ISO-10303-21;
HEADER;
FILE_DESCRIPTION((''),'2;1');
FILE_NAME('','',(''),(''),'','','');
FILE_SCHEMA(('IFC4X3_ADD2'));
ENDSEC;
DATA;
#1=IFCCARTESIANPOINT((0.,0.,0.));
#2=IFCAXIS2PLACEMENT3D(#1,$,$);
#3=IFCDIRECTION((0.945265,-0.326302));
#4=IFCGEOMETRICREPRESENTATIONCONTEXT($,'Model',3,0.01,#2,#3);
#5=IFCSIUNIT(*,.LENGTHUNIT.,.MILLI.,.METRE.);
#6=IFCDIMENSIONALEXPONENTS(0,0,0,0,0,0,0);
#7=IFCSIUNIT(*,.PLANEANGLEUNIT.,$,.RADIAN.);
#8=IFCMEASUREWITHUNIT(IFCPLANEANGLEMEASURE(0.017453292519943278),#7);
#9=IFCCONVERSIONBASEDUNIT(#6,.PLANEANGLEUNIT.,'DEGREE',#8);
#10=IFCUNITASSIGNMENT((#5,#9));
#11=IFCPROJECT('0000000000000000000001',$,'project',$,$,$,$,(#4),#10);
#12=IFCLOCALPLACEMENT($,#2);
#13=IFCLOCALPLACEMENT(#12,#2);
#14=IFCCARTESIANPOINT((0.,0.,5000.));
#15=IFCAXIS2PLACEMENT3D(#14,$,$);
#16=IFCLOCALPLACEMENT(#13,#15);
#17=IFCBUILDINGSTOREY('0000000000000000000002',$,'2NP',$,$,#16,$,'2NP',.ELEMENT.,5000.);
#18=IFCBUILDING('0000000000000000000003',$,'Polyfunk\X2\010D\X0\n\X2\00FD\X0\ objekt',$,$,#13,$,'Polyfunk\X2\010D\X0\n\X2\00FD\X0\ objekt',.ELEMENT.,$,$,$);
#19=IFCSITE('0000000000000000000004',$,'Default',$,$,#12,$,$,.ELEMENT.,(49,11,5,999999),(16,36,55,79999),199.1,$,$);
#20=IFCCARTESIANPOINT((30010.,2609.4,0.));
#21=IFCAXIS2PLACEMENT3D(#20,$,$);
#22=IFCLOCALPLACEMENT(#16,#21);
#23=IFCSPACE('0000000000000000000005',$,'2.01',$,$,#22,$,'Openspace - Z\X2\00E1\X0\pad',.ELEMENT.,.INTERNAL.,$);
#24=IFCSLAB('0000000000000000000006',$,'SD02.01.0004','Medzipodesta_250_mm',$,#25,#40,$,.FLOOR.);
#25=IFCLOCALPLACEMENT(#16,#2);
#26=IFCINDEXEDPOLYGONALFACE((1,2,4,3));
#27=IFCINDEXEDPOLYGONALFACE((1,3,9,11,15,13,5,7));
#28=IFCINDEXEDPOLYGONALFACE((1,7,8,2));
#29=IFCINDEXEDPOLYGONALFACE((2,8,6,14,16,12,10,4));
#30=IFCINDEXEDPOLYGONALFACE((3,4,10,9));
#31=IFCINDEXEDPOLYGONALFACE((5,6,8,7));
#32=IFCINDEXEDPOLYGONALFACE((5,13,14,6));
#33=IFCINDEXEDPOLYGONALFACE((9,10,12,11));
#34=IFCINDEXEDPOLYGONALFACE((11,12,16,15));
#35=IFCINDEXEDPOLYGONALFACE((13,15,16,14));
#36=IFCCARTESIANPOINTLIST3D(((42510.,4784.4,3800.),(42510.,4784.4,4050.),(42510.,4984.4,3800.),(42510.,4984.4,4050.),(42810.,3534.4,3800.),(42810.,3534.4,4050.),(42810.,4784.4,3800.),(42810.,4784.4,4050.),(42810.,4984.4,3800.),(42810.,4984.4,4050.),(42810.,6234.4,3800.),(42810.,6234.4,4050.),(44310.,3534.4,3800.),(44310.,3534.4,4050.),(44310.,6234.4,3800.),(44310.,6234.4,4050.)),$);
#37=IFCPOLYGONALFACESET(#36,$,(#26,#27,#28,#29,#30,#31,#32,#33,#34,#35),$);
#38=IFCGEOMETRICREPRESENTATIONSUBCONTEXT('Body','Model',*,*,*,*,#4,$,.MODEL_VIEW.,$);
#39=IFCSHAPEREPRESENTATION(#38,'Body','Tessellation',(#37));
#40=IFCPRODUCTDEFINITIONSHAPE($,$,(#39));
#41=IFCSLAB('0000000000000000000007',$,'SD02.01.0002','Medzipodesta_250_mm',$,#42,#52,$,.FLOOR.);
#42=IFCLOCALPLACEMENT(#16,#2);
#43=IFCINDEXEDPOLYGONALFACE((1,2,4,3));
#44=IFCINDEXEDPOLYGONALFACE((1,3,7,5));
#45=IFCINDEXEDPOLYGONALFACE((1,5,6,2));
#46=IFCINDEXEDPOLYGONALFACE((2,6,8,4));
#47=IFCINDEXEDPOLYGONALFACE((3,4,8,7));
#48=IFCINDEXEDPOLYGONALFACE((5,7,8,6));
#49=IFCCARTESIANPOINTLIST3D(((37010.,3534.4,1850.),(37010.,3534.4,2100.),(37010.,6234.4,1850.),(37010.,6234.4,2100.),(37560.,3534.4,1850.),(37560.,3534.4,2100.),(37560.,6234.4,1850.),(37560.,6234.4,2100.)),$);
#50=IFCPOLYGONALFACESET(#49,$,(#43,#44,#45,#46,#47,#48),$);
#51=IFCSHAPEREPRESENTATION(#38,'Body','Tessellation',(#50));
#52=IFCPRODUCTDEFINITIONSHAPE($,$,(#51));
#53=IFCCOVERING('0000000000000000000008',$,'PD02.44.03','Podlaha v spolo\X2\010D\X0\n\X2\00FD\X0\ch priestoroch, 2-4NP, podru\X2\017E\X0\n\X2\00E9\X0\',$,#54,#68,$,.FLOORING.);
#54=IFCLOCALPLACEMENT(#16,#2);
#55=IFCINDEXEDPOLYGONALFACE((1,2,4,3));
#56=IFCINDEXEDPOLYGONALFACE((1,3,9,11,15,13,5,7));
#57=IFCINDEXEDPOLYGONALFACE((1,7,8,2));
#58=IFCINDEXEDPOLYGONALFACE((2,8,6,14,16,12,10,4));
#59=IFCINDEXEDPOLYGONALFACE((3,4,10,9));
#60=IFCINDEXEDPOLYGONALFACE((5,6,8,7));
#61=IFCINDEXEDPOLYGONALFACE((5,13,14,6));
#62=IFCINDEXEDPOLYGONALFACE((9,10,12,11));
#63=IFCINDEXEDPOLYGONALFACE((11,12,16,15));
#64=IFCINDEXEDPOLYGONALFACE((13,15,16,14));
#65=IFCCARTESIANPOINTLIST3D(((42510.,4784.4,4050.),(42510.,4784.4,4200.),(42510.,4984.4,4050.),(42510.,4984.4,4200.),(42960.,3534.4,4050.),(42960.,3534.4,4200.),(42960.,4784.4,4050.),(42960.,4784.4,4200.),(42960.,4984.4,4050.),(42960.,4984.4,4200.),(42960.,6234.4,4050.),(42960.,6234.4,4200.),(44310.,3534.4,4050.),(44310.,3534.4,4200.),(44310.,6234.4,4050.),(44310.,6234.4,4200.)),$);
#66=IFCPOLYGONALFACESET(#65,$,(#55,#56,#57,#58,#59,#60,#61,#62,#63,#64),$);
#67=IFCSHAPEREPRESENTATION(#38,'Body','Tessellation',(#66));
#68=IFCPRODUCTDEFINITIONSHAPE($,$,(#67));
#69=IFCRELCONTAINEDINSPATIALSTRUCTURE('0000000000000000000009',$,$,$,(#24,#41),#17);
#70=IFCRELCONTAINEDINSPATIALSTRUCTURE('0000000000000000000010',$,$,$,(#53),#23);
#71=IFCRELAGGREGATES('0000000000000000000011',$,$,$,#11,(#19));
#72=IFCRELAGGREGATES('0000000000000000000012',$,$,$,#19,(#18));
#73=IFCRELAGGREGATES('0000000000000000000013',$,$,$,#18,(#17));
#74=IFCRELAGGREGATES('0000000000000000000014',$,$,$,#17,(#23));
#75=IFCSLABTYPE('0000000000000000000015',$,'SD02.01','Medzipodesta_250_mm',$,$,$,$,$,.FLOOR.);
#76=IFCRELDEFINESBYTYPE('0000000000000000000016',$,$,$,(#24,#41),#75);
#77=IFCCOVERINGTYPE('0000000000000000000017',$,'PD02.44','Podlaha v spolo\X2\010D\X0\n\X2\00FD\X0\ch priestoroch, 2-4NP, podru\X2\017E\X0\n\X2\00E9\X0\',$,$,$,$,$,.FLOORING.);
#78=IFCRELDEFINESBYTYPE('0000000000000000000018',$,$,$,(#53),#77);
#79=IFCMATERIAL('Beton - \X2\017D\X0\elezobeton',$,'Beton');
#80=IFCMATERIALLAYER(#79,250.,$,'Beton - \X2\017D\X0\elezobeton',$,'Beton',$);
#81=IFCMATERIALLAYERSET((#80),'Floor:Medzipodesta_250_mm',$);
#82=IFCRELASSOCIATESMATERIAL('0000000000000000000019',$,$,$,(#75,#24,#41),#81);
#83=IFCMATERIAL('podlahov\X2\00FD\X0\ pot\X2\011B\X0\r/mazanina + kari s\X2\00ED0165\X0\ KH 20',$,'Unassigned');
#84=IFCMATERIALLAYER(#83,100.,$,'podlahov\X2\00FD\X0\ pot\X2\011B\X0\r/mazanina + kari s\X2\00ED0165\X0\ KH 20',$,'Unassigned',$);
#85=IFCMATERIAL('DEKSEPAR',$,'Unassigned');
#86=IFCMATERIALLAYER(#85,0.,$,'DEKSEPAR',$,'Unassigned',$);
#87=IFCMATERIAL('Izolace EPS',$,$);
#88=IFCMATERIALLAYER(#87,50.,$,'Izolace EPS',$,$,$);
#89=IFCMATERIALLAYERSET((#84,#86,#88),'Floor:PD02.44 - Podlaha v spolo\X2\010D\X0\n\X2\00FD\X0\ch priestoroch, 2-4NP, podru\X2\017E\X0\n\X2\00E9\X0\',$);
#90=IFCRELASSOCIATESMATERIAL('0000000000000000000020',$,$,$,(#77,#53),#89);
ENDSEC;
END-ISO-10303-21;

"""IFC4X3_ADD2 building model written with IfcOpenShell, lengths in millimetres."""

from ifc_helpers import new_model, entity, si_unit, converted_unit, direction, frame, frame_2d, origin, place, context, subcontext, project, spatial, polyline, rectangle, outline, extrude, material, layer, layer_set, layer_usage, type_object, element, save


model = new_model("IFC4X3_ADD2")

# Units and contexts
model_context = context("Model", 3, precision=0.01, world=origin(), true_north=direction((0.945265, -0.326302)))
body_context = subcontext(model_context, "Body", "Model", "MODEL_VIEW")
ifc_project = project(units=[si_unit("LENGTHUNIT", "METRE", prefix="MILLI"), converted_unit("PLANEANGLEUNIT", "DEGREE", entity("IfcPlaneAngleMeasure", 0.017453292519943278), si_unit("PLANEANGLEUNIT", "RADIAN"), dimensions=[0, 0, 0, 0, 0, 0, 0])], contexts=[model_context])

# Site, building, storey
site_placement = place(None, origin())
site = spatial("IfcSite", under=ifc_project, at=site_placement, Name="Default", CompositionType="ELEMENT", RefLatitude=(49, 11, 5, 999999), RefLongitude=(16, 36, 55, 79999), RefElevation=199.1)
building_placement = place(site_placement, origin())
building = spatial("IfcBuilding", under=site, at=building_placement, Name="Polyfunkčný objekt", LongName="Polyfunkčný objekt", CompositionType="ELEMENT")
storey_placement = place(building_placement, frame((0.0, 0.0, 5000.0)))
storey = spatial("IfcBuildingStorey", under=building, at=storey_placement, Name="2NP", LongName="2NP", CompositionType="ELEMENT", Elevation=5000.0)

# Shared definitions
ifc_material_1 = material(Name="Beton - Železobeton", Category="Beton")

# Slabs
ifc_layer_1 = layer(ifc_material_1, 250.0, Name="Beton - Železobeton", Category="Beton")
ifc_layer_set_1 = layer_set([ifc_layer_1], Name="Floor:Medzipodesta_250_mm")
ifc_layer_usage_1 = layer_usage(ifc_layer_set_1, "AXIS3", "POSITIVE", 0.0)
slab_type_1 = type_object("IfcSlabType", Name="SD02.01", Description="Medzipodesta_250_mm", PredefinedType="FLOOR", material=ifc_layer_set_1)
slab_1_placement = place(storey_placement, origin())
element("IfcSlab", 1, at=slab_1_placement, inside=storey, type_object=slab_type_1, material=ifc_layer_usage_1, Name="SD02.01.0004", Description="Medzipodesta_250_mm", PredefinedType="FLOOR", context=body_context, shape_type="SweptSolid", body=[
    extrude(outline(polyline([(-100.0, -600.0), (100.0, -600.0), (100.0, -300.0), (1350.0, -300.0), (1350.0, 1200.0), (-1350.0, 1200.0), (-1350.0, -300.0), (-100.0, -300.0), (-100.0, -600.0)])), frame((43110.0, 4884.4, 4050.0), z_axis=(0.0, 0.0, -1.0), x_axis=(0.0, 1.0, 0.0)), (0.0, 0.0, 1.0), 250.0),
])
ifc_layer_usage_2 = layer_usage(ifc_layer_set_1, "AXIS3", "POSITIVE", 0.0)
slab_2_placement = place(storey_placement, origin())
element("IfcSlab", 2, at=slab_2_placement, inside=storey, type_object=slab_type_1, material=ifc_layer_usage_2, Name="SD02.01.0002", Description="Medzipodesta_250_mm", PredefinedType="FLOOR", context=body_context, shape_type="SweptSolid", body=[
    extrude(rectangle(XDim=2700.0, YDim=550.0, at=frame_2d((0.0, 0.0), x_axis=(1.0, 0.0))), frame((37285.0, 4884.4, 2100.0), z_axis=(0.0, 0.0, -1.0), x_axis=(0.0, 1.0, 0.0)), (0.0, 0.0, 1.0), 250.0),
])

# Shared definitions
space_1_placement = place(storey_placement, frame((30010.0, 2609.4, 0.0)))
space_1 = spatial("IfcSpace", under=storey, at=space_1_placement, Name="2.01", LongName="Openspace - Západ", CompositionType="ELEMENT", PredefinedType="INTERNAL")

# Covering
ifc_material_2 = material(Name="podlahový potěr/mazanina + kari síť KH 20", Category="Unassigned")
ifc_layer_2 = layer(ifc_material_2, 100.0, Name="podlahový potěr/mazanina + kari síť KH 20", Category="Unassigned")
ifc_material_3 = material(Name="DEKSEPAR", Category="Unassigned")
ifc_layer_3 = layer(ifc_material_3, 0.0, Name="DEKSEPAR", Category="Unassigned")
ifc_material_4 = material(Name="Izolace EPS")
ifc_layer_4 = layer(ifc_material_4, 50.0, Name="Izolace EPS")
ifc_layer_set_2 = layer_set([ifc_layer_2, ifc_layer_3, ifc_layer_4], Name="Floor:PD02.44 - Podlaha v spoločných priestoroch, 2-4NP, podružné")
ifc_layer_usage_3 = layer_usage(ifc_layer_set_2, "AXIS3", "POSITIVE", 0.0)
covering_type_1 = type_object("IfcCoveringType", Name="PD02.44", Description="Podlaha v spoločných priestoroch, 2-4NP, podružné", PredefinedType="FLOORING", material=ifc_layer_set_2)
placement = place(building_placement, frame((0.0, 0.0, 9200.0)))
covering_1_placement = place(placement, origin())
element("IfcCovering", 3, at=covering_1_placement, inside=space_1, type_object=covering_type_1, material=ifc_layer_usage_3, Name="PD02.44.03", Description="Podlaha v spoločných priestoroch, 2-4NP, podružné", PredefinedType="FLOORING", context=body_context, shape_type="SweptSolid", body=[
    extrude(outline(polyline([(-100.0, -675.0), (100.0, -675.0), (100.0, -225.0), (1350.0, -225.0), (1350.0, 1125.0), (-1350.0, 1125.0), (-1350.0, -225.0), (-100.0, -225.0), (-100.0, -675.0)])), frame((43185.0, 4884.4, 0.0), z_axis=(0.0, 0.0, -1.0), x_axis=(0.0, 1.0, 0.0)), (0.0, 0.0, 1.0), 150.0),
])

save(model, "model.ifc")
